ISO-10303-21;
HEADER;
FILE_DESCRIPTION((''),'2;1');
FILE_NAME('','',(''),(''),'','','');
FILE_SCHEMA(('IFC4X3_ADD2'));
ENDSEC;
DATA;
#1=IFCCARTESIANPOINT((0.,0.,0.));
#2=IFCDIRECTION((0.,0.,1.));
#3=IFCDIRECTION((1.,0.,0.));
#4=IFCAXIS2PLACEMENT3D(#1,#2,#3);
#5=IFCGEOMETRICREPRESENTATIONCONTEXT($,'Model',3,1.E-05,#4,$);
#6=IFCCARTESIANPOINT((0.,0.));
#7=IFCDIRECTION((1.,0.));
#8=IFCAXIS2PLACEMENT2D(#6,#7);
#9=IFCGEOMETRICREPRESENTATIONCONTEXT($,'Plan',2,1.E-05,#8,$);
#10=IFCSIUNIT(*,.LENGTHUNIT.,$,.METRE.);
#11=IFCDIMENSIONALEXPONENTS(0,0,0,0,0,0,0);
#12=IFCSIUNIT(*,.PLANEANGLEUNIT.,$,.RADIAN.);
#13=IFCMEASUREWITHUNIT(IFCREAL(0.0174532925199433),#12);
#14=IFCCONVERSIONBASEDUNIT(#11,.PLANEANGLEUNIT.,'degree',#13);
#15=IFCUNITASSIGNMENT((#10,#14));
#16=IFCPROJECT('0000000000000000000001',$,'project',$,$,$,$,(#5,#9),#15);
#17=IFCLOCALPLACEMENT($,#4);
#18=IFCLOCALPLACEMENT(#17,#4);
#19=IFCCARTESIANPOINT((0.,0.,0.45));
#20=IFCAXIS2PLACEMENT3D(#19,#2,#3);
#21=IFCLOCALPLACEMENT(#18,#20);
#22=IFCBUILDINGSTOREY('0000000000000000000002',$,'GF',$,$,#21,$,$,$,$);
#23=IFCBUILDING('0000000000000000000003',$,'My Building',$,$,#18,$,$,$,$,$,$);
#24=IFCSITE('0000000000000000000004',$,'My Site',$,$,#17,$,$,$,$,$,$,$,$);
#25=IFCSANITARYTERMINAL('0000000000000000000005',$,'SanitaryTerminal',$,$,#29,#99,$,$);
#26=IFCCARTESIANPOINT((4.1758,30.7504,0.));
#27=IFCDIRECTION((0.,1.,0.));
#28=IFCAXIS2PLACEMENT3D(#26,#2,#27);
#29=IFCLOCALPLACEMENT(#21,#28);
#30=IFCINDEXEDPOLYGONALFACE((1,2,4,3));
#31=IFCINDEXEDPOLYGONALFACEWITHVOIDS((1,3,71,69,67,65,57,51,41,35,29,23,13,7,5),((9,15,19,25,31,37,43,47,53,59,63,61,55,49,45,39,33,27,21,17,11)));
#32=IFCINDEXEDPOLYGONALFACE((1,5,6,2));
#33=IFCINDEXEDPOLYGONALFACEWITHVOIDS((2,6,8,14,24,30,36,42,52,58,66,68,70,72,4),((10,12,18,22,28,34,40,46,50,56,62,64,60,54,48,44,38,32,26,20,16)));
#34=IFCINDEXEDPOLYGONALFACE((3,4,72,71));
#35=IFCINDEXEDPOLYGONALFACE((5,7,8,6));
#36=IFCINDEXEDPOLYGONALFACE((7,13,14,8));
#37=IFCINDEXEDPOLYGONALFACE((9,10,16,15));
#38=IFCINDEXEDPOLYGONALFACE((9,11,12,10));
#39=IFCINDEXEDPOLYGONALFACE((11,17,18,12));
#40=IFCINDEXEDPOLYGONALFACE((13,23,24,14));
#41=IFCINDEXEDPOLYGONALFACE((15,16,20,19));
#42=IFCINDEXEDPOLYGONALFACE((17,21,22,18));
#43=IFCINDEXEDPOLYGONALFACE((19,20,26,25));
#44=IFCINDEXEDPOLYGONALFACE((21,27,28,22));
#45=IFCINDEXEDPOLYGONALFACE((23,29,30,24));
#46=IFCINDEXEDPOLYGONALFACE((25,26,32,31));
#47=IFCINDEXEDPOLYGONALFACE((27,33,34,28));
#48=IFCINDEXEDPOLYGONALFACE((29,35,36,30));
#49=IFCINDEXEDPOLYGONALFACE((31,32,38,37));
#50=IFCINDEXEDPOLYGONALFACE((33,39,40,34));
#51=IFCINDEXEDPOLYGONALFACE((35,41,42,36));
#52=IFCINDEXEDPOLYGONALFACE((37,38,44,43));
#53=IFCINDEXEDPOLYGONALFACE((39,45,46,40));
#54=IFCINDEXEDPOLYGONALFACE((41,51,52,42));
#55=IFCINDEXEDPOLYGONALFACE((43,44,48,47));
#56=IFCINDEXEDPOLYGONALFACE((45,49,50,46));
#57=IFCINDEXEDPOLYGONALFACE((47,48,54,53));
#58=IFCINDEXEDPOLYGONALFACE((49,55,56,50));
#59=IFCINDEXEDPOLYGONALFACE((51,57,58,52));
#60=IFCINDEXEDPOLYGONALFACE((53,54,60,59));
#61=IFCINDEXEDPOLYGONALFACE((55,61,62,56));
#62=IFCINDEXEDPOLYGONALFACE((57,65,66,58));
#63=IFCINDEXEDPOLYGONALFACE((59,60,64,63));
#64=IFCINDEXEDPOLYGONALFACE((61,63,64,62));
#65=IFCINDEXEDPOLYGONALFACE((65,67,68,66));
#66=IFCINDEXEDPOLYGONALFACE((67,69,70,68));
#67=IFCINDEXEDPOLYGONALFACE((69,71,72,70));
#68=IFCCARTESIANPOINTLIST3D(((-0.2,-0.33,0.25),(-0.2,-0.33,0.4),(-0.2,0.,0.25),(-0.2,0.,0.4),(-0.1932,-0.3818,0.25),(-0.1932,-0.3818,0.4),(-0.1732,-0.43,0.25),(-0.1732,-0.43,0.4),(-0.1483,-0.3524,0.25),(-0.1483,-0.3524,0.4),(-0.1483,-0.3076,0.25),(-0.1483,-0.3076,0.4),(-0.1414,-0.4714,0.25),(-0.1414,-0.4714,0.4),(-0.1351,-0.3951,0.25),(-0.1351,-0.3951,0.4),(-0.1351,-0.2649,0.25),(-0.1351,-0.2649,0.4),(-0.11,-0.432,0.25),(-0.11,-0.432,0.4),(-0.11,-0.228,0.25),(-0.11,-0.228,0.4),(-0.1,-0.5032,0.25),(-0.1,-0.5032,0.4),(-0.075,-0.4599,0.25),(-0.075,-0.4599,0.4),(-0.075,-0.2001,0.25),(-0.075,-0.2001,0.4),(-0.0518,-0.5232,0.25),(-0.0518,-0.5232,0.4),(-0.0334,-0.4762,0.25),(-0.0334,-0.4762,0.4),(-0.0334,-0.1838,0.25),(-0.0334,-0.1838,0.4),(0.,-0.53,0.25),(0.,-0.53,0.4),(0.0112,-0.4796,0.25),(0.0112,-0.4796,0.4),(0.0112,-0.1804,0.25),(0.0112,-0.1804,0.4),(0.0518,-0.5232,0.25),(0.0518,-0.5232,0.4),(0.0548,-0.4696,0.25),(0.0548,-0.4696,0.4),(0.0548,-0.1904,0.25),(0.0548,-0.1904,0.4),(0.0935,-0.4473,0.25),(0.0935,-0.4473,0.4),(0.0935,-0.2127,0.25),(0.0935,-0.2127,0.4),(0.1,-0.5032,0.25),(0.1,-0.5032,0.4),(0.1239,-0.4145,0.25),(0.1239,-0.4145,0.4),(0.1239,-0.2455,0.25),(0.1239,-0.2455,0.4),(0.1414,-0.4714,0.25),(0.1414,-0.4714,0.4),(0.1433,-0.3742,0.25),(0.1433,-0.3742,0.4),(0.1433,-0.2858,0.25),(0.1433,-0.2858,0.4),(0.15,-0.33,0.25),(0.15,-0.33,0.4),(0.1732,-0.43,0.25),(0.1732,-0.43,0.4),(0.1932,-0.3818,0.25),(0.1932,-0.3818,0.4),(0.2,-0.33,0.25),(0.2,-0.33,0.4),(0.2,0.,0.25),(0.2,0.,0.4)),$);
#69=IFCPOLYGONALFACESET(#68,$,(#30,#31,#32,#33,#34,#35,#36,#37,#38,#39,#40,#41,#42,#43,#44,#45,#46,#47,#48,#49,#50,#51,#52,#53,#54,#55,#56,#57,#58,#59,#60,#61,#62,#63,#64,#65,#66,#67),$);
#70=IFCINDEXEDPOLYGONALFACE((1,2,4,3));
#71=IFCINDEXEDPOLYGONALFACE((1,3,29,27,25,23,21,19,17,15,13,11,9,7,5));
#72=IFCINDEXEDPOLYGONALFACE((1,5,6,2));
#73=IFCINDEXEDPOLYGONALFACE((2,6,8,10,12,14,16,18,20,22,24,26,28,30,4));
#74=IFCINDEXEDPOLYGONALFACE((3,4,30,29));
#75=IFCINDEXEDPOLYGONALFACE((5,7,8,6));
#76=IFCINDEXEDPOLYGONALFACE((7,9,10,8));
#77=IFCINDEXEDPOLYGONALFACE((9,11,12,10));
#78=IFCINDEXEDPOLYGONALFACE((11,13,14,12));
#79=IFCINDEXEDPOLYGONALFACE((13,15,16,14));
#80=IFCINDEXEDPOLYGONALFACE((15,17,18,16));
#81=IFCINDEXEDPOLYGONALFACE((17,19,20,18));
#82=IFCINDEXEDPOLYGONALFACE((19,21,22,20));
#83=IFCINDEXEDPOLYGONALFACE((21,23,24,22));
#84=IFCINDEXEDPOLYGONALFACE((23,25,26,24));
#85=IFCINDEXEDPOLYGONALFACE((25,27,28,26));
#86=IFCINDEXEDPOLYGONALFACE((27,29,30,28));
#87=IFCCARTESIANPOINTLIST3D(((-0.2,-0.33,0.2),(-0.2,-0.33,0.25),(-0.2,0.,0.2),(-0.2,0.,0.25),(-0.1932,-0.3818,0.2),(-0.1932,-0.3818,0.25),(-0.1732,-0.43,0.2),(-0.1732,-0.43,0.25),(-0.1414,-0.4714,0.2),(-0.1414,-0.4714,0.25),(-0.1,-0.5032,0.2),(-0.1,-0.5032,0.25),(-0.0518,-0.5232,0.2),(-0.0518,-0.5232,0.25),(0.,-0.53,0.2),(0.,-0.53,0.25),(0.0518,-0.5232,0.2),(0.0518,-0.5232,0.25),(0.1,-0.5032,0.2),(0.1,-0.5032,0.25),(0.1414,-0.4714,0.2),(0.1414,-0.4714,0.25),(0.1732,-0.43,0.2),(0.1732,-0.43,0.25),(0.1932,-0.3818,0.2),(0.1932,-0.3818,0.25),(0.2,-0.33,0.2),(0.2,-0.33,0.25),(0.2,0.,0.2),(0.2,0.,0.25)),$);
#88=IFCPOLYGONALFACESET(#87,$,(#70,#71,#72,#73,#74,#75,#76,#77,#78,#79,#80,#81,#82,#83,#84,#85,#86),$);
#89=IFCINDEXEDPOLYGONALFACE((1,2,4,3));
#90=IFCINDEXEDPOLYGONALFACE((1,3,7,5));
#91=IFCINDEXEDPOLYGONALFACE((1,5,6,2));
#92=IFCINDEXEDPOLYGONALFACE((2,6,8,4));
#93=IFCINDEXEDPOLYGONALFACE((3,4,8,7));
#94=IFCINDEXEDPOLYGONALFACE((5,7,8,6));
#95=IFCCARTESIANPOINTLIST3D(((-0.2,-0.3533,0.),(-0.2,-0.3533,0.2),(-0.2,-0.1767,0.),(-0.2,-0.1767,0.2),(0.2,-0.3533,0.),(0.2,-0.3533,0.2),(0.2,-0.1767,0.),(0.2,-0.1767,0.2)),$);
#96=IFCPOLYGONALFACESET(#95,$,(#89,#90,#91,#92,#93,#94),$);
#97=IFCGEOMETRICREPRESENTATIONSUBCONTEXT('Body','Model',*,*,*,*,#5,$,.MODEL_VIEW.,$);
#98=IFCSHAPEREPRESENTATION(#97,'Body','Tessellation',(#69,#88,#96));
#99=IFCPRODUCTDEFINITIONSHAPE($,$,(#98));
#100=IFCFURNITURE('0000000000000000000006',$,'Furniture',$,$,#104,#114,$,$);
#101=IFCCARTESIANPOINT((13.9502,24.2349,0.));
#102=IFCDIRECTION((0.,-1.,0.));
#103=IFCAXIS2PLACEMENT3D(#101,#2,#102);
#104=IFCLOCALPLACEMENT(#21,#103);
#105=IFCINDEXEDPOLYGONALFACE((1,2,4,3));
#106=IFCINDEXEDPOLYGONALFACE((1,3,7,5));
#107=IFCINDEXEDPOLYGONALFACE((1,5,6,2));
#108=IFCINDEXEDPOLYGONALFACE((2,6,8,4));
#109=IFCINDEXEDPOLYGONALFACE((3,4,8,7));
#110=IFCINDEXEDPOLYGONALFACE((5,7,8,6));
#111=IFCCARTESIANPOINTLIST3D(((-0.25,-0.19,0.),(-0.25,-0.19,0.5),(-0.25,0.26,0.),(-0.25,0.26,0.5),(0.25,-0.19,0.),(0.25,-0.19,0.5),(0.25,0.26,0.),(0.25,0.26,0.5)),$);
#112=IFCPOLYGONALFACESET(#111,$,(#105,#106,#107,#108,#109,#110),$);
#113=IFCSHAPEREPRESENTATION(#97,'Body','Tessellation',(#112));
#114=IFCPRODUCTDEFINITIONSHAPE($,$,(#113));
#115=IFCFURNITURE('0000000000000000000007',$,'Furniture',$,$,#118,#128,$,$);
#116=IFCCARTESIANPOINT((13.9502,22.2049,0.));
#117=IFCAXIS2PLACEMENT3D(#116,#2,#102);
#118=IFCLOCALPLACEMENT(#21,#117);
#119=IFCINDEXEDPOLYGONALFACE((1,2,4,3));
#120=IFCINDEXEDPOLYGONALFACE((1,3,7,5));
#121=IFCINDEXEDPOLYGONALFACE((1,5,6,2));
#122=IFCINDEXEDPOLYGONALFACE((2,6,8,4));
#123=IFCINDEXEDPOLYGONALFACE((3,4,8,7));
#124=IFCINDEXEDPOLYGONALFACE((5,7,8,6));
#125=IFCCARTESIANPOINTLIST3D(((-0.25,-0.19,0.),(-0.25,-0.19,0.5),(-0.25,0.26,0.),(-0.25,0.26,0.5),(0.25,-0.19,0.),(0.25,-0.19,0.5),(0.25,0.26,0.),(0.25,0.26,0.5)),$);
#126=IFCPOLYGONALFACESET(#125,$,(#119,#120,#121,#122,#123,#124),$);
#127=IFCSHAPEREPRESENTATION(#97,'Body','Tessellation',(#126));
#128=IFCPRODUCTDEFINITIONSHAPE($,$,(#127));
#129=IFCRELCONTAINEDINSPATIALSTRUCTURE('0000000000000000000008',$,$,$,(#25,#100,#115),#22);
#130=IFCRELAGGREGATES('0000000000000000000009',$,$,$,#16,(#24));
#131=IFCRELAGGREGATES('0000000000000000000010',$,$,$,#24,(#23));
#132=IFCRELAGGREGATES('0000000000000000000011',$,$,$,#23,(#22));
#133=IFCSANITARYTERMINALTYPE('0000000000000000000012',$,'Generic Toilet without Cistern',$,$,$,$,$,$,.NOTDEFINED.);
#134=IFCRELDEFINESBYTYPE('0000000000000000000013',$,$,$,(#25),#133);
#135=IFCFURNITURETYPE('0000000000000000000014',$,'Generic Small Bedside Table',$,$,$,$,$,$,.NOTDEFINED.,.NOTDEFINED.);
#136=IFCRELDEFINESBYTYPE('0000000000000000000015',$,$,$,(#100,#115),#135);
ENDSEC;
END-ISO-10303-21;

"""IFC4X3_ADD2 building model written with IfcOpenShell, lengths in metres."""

from ifc_helpers import new_model, entity, si_unit, converted_unit, frame, frame_2d, origin_with_axes, origin_2d_with_axis, place, context, subcontext, project, spatial, line, arc, indexed_curve, circle_curve, outline, extrude, shape, source, transform, mapped, type_object, type_shapes, element, save


model = new_model("IFC4X3_ADD2")

# Units and contexts
model_context = context("Model", 3, precision=1e-05, world=origin_with_axes())
plan_context = context("Plan", 2, precision=1e-05, world=origin_2d_with_axis())
body_context_1 = subcontext(model_context, "Body", "Model", "MODEL_VIEW")
body_context_2 = subcontext(plan_context, "Body", "Plan", "PLAN_VIEW")
ifc_project = project(units=[si_unit("LENGTHUNIT", "METRE"), converted_unit("PLANEANGLEUNIT", "degree", entity("IfcReal", 0.0174532925199433), si_unit("PLANEANGLEUNIT", "RADIAN"), dimensions=[0, 0, 0, 0, 0, 0, 0])], contexts=[model_context, plan_context])

# Site, building, storey
site_placement = place(None, origin_with_axes())
site = spatial("IfcSite", under=ifc_project, at=site_placement, Name="My Site")
building_placement = place(site_placement, origin_with_axes())
building = spatial("IfcBuilding", under=site, at=building_placement, Name="My Building")
storey_placement = place(building_placement, frame((0.0, 0.0, 0.45), z_axis=(0.0, 0.0, 1.0), x_axis=(1.0, 0.0, 0.0)))
storey = spatial("IfcBuildingStorey", under=building, at=storey_placement, Name="GF")

# Sanitary terminal
sanitary_terminal_type_1 = type_object("IfcSanitaryTerminalType", Name="Generic Toilet without Cistern", PredefinedType="NOTDEFINED")
shared_shape_1 = source(origin_with_axes(), body_context_1, "Body", "SweptSolid", [
    extrude(outline(indexed_curve([(-0.2, 0.0), (0.2, 0.0), (0.2, -0.33), (0.1414, -0.4714), (0.0, -0.53), (-0.1414, -0.4714), (-0.2, -0.33)], segments=[line(1, 2), line(2, 3), arc(3, 4, 5), arc(5, 6, 7), line(7, 1)]), holes=[circle_curve(frame_2d((0.0, -0.33)), 0.15)]), frame((0.0, 0.0, 0.25), z_axis=(0.0, 0.0, 1.0), x_axis=(1.0, 0.0, 0.0)), (0.0, 0.0, 1.0), 0.15),
    extrude(outline(indexed_curve([(-0.2, 0.0), (0.2, 0.0), (0.2, -0.33), (0.1414, -0.4714), (0.0, -0.53), (-0.1414, -0.4714), (-0.2, -0.33)], segments=[line(1, 2), line(2, 3), arc(3, 4, 5), arc(5, 6, 7), line(7, 1)])), frame((0.0, 0.0, 0.2), z_axis=(0.0, 0.0, 1.0), x_axis=(1.0, 0.0, 0.0)), (0.0, 0.0, 1.0), 0.05),
    extrude(outline(indexed_curve([(-0.2, -0.1767), (0.2, -0.1767), (0.2, -0.3533), (-0.2, -0.3533)], segments=[line(1, 2, 3, 4, 1)])), origin_with_axes(), (0.0, 0.0, 1.0), 0.2),
])
shared_shape_2 = source(origin_with_axes(), body_context_2, "Body", "Annotation2D", [
    entity("IfcGeometricCurveSet", [entity("IfcIndexedPolyCurve", entity("IfcCartesianPointList2D", [[-0.1068, -0.124], [-0.0957, -0.1129], [-0.0804, -0.1088], [0.0804, -0.1088], [0.0957, -0.1129], [0.1068, -0.124], [0.1109, -0.1393], [0.1109, -0.3476], [0.1025, -0.3926], [0.0784, -0.4308], [0.0424, -0.4563], [0.0, -0.4652], [-0.0424, -0.4563], [-0.0784, -0.4308], [-0.1025, -0.3926], [-0.1109, -0.3476], [-0.1109, -0.1393]]), [entity("IfcLineIndex", [1, 2, 3, 4, 5, 6, 7, 8, 9, 10, 11, 12, 13, 14, 15, 16, 17, 1])]), entity("IfcIndexedPolyCurve", entity("IfcCartesianPointList2D", [[-0.1962, -0.2314], [-0.1848, -0.301], [-0.1764, -0.3339], [-0.1663, -0.3651], [-0.1546, -0.3944], [-0.1414, -0.4213], [-0.1269, -0.4458], [-0.1111, -0.4675], [-0.0943, -0.4862], [-0.0765, -0.5018], [-0.0581, -0.514], [-0.039, -0.5229], [-0.0196, -0.5282], [0.0, -0.53], [0.0196, -0.5282], [0.039, -0.5229], [0.0581, -0.514], [0.0765, -0.5018], [0.0943, -0.4862], [0.1111, -0.4675], [0.1269, -0.4458], [0.1414, -0.4213], [0.1546, -0.3944], [0.1663, -0.3651], [0.1764, -0.3339], [0.1848, -0.301], [0.1962, -0.2314], [0.2, -0.159], [0.1872, 0.0], [-0.1872, 0.0], [-0.2, -0.159]]), [entity("IfcLineIndex", [1, 2, 3, 4, 5, 6, 7, 8, 9, 10, 11, 12, 13, 14, 15, 16, 17, 18, 19, 20, 21, 22, 23, 24, 25, 26, 27, 28, 29, 30, 31, 1])])]),
])
type_shapes(sanitary_terminal_type_1, [shared_shape_1, shared_shape_2])
for number, where, z_axis, x_axis, name in (
    (1, (4.1758, 30.7504, 0.0), (0.0, 0.0, 1.0), (0.0, 1.0, 0.0), "SanitaryTerminal"),
):
    element("IfcSanitaryTerminal", number, at=place(storey_placement, frame(where, z_axis=z_axis, x_axis=x_axis)), inside=storey, type_object=sanitary_terminal_type_1, Name=name, shapes=[
        shape(body_context_1, "Body", "MappedRepresentation", [mapped(shared_shape_1, transform((0.0, 0.0, 0.0), x_axis=(1.0, 0.0, 0.0), y_axis=(0.0, 1.0, 0.0), z_axis=(0.0, 0.0, 1.0), scale=1.0))]),
        shape(body_context_2, "Body", "MappedRepresentation", [mapped(shared_shape_2, transform((0.0, 0.0, 0.0), x_axis=(1.0, 0.0, 0.0), y_axis=(0.0, 1.0, 0.0), z_axis=(0.0, 0.0, 1.0), scale=1.0))]),
    ])

# Furniture
furniture_type_1 = type_object("IfcFurnitureType", Name="Generic Small Bedside Table", AssemblyPlace="NOTDEFINED", PredefinedType="NOTDEFINED")
shared_shape_3 = source(origin_with_axes(), body_context_1, "Body", "SweptSolid", [
    extrude(outline(indexed_curve([(0.0, 0.0), (0.5, 0.0), (0.5, 0.45), (0.0, 0.45), (0.0, 0.0)])), frame((-0.25, -0.19, 0.0), z_axis=(0.0, 0.0, 1.0), x_axis=(1.0, 0.0, 0.0)), (0.0, 0.0, 1.0), 0.5),
])
shared_shape_4 = source(origin_with_axes(), body_context_2, "Body", "Annotation2D", [
    entity("IfcGeometricCurveSet", [entity("IfcIndexedPolyCurve", entity("IfcCartesianPointList2D", [[-0.25, -0.19], [0.25, -0.19], [0.25, 0.26], [-0.25, 0.26]]), [entity("IfcLineIndex", [1, 2]), entity("IfcLineIndex", [2, 3]), entity("IfcLineIndex", [3, 4]), entity("IfcLineIndex", [4, 1])])]),
])
type_shapes(furniture_type_1, [shared_shape_3, shared_shape_4])
for number, where, z_axis, x_axis, name in (
    (2, (13.9502, 24.2349, 0.0), (0.0, 0.0, 1.0), (0.0, -1.0, 0.0), "Furniture"),
    (3, (13.9502, 22.2049, 0.0), (0.0, 0.0, 1.0), (0.0, -1.0, 0.0), "Furniture"),
):
    element("IfcFurniture", number, at=place(storey_placement, frame(where, z_axis=z_axis, x_axis=x_axis)), inside=storey, type_object=furniture_type_1, Name=name, shapes=[
        shape(body_context_1, "Body", "MappedRepresentation", [mapped(shared_shape_3, transform((0.0, 0.0, 0.0), x_axis=(1.0, 0.0, 0.0), y_axis=(0.0, 1.0, 0.0), z_axis=(0.0, 0.0, 1.0), scale=1.0))]),
        shape(body_context_2, "Body", "MappedRepresentation", [mapped(shared_shape_4, transform((0.0, 0.0, 0.0), x_axis=(1.0, 0.0, 0.0), y_axis=(0.0, 1.0, 0.0), z_axis=(0.0, 0.0, 1.0), scale=1.0))]),
    ])

save(model, "model.ifc")
